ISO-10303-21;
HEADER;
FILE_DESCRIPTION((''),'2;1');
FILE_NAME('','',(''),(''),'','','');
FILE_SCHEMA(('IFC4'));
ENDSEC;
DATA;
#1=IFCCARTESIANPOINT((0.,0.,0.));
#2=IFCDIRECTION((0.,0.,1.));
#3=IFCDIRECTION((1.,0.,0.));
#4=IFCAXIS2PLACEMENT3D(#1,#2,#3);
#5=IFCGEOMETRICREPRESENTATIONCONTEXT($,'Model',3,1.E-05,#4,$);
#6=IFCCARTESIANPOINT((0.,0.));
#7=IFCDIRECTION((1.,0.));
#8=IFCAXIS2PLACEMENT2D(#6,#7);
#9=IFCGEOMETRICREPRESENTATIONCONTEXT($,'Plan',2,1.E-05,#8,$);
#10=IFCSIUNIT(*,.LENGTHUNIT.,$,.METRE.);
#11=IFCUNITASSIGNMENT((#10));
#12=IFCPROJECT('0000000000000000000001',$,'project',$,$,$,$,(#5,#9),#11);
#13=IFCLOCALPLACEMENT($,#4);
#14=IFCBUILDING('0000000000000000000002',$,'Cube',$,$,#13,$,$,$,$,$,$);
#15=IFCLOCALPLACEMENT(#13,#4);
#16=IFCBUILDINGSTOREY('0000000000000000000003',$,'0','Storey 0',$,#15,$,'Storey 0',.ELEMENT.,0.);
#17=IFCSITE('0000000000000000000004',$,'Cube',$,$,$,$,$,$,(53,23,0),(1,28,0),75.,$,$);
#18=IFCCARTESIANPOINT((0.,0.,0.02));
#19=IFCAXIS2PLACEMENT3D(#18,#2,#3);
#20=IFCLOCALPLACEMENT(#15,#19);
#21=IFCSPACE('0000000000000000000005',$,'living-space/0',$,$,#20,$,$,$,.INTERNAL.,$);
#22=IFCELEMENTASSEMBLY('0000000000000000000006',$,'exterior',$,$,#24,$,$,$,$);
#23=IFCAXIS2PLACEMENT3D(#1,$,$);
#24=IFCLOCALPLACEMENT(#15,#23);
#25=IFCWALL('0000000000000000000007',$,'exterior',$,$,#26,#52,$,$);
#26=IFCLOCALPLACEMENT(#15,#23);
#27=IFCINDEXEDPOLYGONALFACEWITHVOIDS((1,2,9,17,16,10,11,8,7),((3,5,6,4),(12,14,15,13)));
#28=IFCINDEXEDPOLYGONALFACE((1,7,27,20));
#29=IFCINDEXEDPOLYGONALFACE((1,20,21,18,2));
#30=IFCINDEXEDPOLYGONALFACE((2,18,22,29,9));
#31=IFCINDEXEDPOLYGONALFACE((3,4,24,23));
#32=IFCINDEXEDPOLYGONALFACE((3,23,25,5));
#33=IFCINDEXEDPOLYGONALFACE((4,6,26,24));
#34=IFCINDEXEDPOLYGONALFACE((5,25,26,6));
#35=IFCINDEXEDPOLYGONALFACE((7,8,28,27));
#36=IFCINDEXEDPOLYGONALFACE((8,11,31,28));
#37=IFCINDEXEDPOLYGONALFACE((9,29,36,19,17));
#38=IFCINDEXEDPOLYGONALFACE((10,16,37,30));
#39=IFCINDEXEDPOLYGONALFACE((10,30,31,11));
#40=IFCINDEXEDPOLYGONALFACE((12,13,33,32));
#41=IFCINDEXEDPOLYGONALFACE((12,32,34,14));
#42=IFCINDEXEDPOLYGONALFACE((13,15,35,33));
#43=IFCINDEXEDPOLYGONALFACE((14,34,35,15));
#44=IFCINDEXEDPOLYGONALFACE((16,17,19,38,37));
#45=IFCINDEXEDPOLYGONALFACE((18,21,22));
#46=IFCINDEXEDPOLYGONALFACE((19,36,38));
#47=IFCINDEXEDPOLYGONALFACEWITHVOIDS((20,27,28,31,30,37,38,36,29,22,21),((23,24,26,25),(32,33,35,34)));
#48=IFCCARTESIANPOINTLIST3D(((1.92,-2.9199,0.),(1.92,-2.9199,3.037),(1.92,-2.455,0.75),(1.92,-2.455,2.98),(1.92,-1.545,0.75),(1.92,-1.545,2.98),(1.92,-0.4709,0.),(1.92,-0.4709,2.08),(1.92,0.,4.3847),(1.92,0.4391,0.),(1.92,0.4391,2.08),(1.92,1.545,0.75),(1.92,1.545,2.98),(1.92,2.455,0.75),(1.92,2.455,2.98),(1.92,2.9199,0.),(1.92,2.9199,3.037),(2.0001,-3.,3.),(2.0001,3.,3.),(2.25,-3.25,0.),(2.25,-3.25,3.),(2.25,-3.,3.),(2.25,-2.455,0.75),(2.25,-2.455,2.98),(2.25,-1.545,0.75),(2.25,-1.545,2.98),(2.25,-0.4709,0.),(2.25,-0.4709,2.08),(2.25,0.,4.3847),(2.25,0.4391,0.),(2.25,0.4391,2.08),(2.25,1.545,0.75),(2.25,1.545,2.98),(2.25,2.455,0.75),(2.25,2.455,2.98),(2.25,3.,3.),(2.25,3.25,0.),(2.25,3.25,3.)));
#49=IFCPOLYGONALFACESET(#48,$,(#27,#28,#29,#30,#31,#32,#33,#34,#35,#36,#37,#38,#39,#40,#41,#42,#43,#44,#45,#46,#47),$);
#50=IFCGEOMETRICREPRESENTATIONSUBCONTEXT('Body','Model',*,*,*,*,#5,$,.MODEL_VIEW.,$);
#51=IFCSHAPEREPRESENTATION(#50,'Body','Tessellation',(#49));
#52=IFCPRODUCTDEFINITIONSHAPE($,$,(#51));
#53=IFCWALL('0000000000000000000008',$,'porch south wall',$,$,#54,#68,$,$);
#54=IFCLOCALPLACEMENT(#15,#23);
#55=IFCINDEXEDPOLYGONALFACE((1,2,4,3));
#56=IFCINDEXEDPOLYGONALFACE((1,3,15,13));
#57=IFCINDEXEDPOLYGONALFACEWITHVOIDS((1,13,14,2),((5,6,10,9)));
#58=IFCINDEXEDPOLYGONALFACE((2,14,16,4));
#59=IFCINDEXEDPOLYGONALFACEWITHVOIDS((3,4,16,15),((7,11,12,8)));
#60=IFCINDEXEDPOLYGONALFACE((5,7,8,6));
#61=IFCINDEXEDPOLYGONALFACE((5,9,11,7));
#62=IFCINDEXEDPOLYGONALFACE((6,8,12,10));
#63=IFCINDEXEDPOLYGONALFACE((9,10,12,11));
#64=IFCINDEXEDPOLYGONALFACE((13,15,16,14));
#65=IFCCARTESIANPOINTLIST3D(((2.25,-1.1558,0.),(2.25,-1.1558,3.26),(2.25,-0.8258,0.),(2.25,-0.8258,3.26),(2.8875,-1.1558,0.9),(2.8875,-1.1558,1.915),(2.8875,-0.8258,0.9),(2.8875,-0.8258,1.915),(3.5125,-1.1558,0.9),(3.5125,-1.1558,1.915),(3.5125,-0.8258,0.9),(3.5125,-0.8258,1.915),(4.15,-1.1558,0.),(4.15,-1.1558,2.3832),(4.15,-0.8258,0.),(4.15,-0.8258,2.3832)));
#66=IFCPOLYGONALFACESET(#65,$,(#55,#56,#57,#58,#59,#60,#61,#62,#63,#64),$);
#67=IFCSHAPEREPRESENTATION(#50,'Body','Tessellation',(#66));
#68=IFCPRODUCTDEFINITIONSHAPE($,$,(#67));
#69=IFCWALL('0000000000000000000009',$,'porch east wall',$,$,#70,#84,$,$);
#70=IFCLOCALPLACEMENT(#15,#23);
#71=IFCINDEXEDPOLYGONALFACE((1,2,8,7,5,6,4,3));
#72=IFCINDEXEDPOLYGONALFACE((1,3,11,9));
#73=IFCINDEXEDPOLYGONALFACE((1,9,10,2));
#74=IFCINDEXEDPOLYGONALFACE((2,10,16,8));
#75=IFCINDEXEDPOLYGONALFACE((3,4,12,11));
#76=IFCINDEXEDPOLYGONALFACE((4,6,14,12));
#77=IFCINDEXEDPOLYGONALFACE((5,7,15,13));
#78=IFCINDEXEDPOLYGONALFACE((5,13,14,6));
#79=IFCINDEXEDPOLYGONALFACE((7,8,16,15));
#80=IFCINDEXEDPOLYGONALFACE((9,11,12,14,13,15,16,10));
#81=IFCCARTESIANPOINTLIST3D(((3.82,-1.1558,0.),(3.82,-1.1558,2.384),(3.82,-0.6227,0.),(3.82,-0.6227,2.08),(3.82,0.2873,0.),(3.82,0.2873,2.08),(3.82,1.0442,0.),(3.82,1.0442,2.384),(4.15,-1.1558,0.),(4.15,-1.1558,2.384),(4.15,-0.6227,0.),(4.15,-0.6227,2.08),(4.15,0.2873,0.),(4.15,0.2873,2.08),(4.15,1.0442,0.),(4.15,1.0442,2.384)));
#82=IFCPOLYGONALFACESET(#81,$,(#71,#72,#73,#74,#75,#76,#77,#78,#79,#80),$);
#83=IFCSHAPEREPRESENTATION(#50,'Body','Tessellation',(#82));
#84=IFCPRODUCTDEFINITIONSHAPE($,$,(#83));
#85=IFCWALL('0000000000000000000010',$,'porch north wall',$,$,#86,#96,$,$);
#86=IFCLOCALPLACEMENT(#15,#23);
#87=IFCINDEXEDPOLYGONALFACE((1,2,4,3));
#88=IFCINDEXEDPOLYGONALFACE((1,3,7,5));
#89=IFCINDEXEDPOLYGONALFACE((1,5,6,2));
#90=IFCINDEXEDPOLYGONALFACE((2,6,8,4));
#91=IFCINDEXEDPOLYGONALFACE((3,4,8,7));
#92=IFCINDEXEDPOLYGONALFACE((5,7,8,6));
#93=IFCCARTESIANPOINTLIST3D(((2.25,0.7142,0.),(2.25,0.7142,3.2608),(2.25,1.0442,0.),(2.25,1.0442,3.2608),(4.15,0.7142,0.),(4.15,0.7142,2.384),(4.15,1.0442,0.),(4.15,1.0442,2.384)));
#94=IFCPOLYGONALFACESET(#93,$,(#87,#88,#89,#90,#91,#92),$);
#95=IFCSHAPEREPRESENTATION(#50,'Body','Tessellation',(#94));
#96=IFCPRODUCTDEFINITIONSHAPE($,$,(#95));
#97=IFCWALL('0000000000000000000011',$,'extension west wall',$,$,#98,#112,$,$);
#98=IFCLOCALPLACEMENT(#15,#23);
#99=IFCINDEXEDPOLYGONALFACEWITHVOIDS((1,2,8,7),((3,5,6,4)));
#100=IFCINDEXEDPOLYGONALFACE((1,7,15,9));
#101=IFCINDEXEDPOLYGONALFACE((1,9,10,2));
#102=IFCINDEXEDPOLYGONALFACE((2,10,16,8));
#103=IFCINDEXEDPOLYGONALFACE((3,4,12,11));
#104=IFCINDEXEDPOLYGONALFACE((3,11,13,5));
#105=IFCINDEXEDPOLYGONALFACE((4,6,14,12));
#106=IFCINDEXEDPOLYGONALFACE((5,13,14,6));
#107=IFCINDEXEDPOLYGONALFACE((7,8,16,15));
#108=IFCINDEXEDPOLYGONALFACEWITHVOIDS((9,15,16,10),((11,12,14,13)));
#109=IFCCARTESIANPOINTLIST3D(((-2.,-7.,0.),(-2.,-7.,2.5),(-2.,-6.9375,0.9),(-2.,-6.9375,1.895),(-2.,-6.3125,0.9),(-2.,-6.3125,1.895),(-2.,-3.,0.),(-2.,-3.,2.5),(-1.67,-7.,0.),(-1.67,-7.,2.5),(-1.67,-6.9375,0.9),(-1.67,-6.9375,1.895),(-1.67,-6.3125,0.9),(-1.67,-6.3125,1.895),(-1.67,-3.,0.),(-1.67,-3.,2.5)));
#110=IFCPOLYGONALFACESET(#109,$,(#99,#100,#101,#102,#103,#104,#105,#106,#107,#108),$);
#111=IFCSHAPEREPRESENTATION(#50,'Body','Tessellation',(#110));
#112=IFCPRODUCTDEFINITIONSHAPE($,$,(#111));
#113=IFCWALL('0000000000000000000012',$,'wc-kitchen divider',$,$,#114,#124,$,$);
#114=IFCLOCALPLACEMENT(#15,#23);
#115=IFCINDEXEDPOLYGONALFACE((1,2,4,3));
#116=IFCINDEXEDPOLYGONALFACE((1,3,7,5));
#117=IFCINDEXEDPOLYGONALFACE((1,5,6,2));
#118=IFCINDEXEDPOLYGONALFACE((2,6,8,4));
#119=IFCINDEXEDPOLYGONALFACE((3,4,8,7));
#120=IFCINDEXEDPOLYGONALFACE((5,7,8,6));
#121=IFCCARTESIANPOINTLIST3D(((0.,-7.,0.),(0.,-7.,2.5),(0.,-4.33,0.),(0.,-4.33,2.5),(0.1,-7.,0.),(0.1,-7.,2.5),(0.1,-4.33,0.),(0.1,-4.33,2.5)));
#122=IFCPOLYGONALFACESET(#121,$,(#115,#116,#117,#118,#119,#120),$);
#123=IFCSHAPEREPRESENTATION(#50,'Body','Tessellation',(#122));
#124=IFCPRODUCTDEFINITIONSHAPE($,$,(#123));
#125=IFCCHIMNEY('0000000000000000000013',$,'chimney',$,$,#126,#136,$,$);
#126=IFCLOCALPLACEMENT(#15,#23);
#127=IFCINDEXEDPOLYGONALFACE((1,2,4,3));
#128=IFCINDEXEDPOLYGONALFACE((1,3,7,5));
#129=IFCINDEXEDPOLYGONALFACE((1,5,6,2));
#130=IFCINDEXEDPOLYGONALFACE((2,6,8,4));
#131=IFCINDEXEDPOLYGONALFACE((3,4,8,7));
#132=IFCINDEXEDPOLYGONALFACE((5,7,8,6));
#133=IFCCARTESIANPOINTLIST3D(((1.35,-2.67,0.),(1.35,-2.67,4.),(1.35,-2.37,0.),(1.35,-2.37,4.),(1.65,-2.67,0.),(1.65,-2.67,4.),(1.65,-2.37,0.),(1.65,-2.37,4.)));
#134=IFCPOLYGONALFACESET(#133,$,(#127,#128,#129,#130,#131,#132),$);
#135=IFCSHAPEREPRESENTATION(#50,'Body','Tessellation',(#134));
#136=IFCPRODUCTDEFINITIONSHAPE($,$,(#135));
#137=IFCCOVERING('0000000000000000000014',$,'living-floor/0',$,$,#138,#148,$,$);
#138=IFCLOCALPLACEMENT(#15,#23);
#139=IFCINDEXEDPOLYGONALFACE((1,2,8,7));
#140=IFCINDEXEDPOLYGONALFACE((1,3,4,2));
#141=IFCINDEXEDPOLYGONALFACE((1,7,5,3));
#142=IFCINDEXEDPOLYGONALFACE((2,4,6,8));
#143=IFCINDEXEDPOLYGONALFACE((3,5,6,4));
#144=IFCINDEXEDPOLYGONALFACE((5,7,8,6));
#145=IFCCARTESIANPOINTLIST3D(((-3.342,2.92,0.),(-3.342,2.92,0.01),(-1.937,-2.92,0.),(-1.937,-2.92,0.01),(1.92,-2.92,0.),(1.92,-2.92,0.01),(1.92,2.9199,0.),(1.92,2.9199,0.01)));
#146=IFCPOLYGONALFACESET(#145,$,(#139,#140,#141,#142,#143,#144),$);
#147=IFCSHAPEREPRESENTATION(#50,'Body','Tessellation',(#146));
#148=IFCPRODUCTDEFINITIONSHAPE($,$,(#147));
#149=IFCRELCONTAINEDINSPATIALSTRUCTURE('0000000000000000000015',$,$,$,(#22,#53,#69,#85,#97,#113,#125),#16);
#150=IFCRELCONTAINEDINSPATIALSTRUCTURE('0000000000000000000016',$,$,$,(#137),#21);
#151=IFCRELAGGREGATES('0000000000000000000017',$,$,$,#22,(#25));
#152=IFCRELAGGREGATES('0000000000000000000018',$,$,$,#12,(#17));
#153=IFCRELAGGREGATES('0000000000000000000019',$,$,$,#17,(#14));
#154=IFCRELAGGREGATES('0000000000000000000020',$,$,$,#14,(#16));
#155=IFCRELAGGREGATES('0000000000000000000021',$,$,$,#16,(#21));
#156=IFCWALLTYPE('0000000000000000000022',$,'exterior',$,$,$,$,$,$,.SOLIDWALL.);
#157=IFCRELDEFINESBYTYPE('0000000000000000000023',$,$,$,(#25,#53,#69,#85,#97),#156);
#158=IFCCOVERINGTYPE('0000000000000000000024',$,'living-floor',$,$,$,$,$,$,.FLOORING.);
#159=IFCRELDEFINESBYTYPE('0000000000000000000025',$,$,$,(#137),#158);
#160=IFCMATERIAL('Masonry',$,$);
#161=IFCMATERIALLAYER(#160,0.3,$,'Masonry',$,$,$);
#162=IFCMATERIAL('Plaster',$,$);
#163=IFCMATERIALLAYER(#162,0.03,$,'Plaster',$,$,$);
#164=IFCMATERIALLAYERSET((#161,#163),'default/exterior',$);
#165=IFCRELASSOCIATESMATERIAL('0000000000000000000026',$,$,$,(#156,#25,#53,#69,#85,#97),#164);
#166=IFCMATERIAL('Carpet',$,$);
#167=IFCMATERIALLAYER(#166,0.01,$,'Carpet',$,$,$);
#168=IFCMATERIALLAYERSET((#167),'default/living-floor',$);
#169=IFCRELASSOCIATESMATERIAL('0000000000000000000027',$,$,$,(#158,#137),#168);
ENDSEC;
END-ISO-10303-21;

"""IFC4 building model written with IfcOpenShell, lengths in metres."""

from ifc_helpers import new_model, si_unit, frame, origin, origin_with_axes, origin_2d_with_axis, place, context, subcontext, project, spatial, polyline, line, indexed_curve, outline, extrude, clip, halfspace, bounded_halfspace, source, transform, mapped, material, layer, layer_set, layer_usage, type_object, element, aggregate, save


model = new_model("IFC4")

# Units and contexts
model_context = context("Model", 3, precision=1e-05, world=origin_with_axes())
plan_context = context("Plan", 2, precision=1e-05, world=origin_2d_with_axis())
body_context = subcontext(model_context, "Body", "Model", "MODEL_VIEW")
ifc_project = project(units=[si_unit("LENGTHUNIT", "METRE")], contexts=[model_context, plan_context])

# Site, building, storey
site = spatial("IfcSite", under=ifc_project, Name="Cube", RefLatitude=(53, 23, 0), RefLongitude=(1, 28, 0), RefElevation=75.0)
building_placement = place(None, origin_with_axes())
building = spatial("IfcBuilding", under=site, at=building_placement, Name="Cube")
storey_placement = place(building_placement, origin_with_axes())
storey = spatial("IfcBuildingStorey", under=building, at=storey_placement, Name="0", Description="Storey 0", LongName="Storey 0", CompositionType="ELEMENT", Elevation=0.0)

# Element assembly, wall, openings
ifc_material_1 = material(Name="Masonry")
ifc_layer_1 = layer(ifc_material_1, 0.3, Name="Masonry")
ifc_material_2 = material(Name="Plaster")
ifc_layer_2 = layer(ifc_material_2, 0.03, Name="Plaster")
ifc_layer_set_1 = layer_set([ifc_layer_1, ifc_layer_2], Name="default/exterior")
wall_type = type_object("IfcWallType", Name="exterior", PredefinedType="SOLIDWALL", material=ifc_layer_set_1)
assembly_1_placement = place(storey_placement, frame((2.0, -3.0, 0.0), z_axis=(0.0, 0.0, 1.0), x_axis=(0.0, 1.0, 0.0)))
assembly_1 = element("IfcElementAssembly", 1, at=assembly_1_placement, inside=storey, Name="exterior")
ifc_layer_usage_1 = layer_usage(ifc_layer_set_1, "AXIS2", "POSITIVE", -0.25)
wall_1_placement = place(assembly_1_placement, origin_with_axes())
wall_1 = element("IfcWall", 2, at=wall_1_placement, type_object=wall_type, material=ifc_layer_usage_1, Name="exterior", context=body_context, shape_type="Clipping", body=[
    clip(clip(clip(clip(extrude(outline(polyline([(0.0801, 0.08), (-0.25, -0.25), (6.25, -0.25), (5.9199, 0.08), (0.0801, 0.08)])), origin(), (0.0, 0.0, 1.0), 4.385), bounded_halfspace(frame((6.0, 0.0, 3.0), z_axis=(0.419069, 0.0, 0.907954), x_axis=(0.0, -1.0, 0.0)), False, origin(), polyline([(6.0, -1.0), (3.0, -1.0), (3.0, 1.0), (6.0, 1.0), (6.0, -1.0)]))), bounded_halfspace(frame((6.0, 0.0, 3.0), z_axis=(0.0, 0.0, 1.0), x_axis=(0.0, 1.0, 0.0)), False, origin(), polyline([(6.0, 1.0), (7.0, 1.0), (7.0, -1.0), (6.0, -1.0), (6.0, 1.0)]))), bounded_halfspace(frame((3.0, 0.0, 4.3847), z_axis=(-0.419069, 0.0, 0.907954), x_axis=(0.0, -1.0, 0.0)), False, origin(), polyline([(3.0, -1.0), (0.0, -1.0), (0.0, 1.0), (3.0, 1.0), (3.0, -1.0)]))), bounded_halfspace(frame((0.0, 0.0, 3.0), z_axis=(0.0, 0.0, 1.0), x_axis=(0.0, -1.0, 0.0)), False, origin(), polyline([(0.0, -1.0), (-1.0, -1.0), (-1.0, 1.0), (0.0, 1.0), (0.0, -1.0)]))),
])
opening_1_placement = place(wall_1_placement, frame((0.545, -0.25, 0.75), z_axis=(0.0, 0.0, 1.0), x_axis=(1.0, 0.0, 0.0)))
element("IfcOpeningElement", 3, at=opening_1_placement, cuts=wall_1, PredefinedType="OPENING", context=body_context, shape_type="SweptSolid", body=[
    extrude(outline(polyline([(0.0, -0.02), (0.91, -0.02), (0.91, 0.35), (0.0, 0.35), (0.0, -0.02)])), origin(), (0.0, 0.0, 1.0), 2.23),
])
opening_2_placement = place(wall_1_placement, frame((4.545, -0.25, 0.75), z_axis=(0.0, 0.0, 1.0), x_axis=(1.0, 0.0, 0.0)))
element("IfcOpeningElement", 4, at=opening_2_placement, cuts=wall_1, PredefinedType="OPENING", context=body_context, shape_type="SweptSolid", body=[
    extrude(outline(polyline([(0.0, -0.02), (0.91, -0.02), (0.91, 0.35), (0.0, 0.35), (0.0, -0.02)])), origin(), (0.0, 0.0, 1.0), 2.23),
])
shared_shape_1 = source(origin_with_axes(), body_context, "Body", "SweptSolid", [
    extrude(outline(indexed_curve([(0.0, 0.0), (0.91, 0.0), (0.91, 2.08), (0.0, 2.08)], segments=[line(1, 2, 3, 4, 1)])), frame((0.0, -0.6, 0.0), z_axis=(0.0, -1.0, 0.0), x_axis=(1.0, 0.0, 0.0)), (0.0, 0.0, -1.0), 1.2),
])
opening_3_placement = place(wall_1_placement, frame((2.5291, -0.25, 0.0), z_axis=(0.0, 0.0, 1.0), x_axis=(1.0, 0.0, 0.0)))
element("IfcOpeningElement", 5, at=opening_3_placement, cuts=wall_1, PredefinedType="OPENING", context=body_context, shape_type="MappedRepresentation", body=[
    mapped(shared_shape_1, transform((0.0, 0.0, 0.0), x_axis=(1.0, 0.0, 0.0), y_axis=(0.0, 1.0, 0.0), z_axis=(0.0, 0.0, 1.0), scale=1.0)),
])
aggregate(assembly_1, [wall_1])

# Walls, openings
ifc_layer_usage_2 = layer_usage(ifc_layer_set_1, "AXIS2", "POSITIVE", 0.0)
wall_2_placement = place(storey_placement, frame((2.25, -1.1558, 0.0), z_axis=(0.0, 0.0, 1.0), x_axis=(1.0, 0.0, 0.0)))
wall_2 = element("IfcWall", 6, at=wall_2_placement, inside=storey, type_object=wall_type, material=ifc_layer_usage_2, Name="porch south wall", context=body_context, shape_type="Clipping", body=[
    clip(extrude(outline(indexed_curve([(0.0, 0.0), (0.0, 0.33), (1.9, 0.33), (1.9, 0.0), (0.0, 0.0)], self_intersect=False)), origin_with_axes(), (0.0, 0.0, 1.0), 3.5), halfspace(frame((0.0, 0.0, 3.26), z_axis=(0.419, 0.0, 0.908), x_axis=(0.0, 1.0, 0.0)), False)),
])
opening_4_placement = place(wall_2_placement, frame((0.6375, -0.0002, 0.9), z_axis=(0.0, 0.0, 1.0), x_axis=(1.0, 0.0, 0.0)))
element("IfcOpeningElement", 7, at=opening_4_placement, cuts=wall_2, context=body_context, shape_type="SweptSolid", body=[
    extrude(outline(indexed_curve([(0.0, 0.0), (0.0, 0.5), (0.625, 0.5), (0.625, 0.0), (0.0, 0.0)], self_intersect=False)), origin_with_axes(), (0.0, 0.0, 1.0), 1.015),
])
ifc_layer_usage_3 = layer_usage(ifc_layer_set_1, "AXIS2", "POSITIVE", 0.0)
wall_3_placement = place(storey_placement, frame((4.15, -1.1558, 0.0), z_axis=(0.0, 0.0, 1.0), x_axis=(0.0, 1.0, 0.0)))
wall_3 = element("IfcWall", 8, at=wall_3_placement, inside=storey, type_object=wall_type, material=ifc_layer_usage_3, Name="porch east wall", context=body_context, shape_type="SweptSolid", body=[
    extrude(outline(indexed_curve([(0.0, 0.0), (0.0, 0.33), (2.2, 0.33), (2.2, 0.0), (0.0, 0.0)], self_intersect=False)), origin_with_axes(), (0.0, 0.0, 1.0), 2.384),
])
shared_shape_2 = source(origin_with_axes(), body_context, "Body", "SweptSolid", [
    extrude(outline(indexed_curve([(0.0, 0.0), (0.91, 0.0), (0.91, 2.08), (0.0, 2.08)], segments=[line(1, 2, 3, 4, 1)])), frame((0.0, -0.6, 0.0), z_axis=(0.0, -1.0, 0.0), x_axis=(1.0, 0.0, 0.0)), (0.0, 0.0, -1.0), 1.2),
])
opening_5_placement = place(wall_3_placement, frame((0.5331, 0.0, 0.0), z_axis=(0.0, 0.0, 1.0), x_axis=(1.0, 0.0, 0.0)))
element("IfcOpeningElement", 9, at=opening_5_placement, cuts=wall_3, PredefinedType="OPENING", context=body_context, shape_type="MappedRepresentation", body=[
    mapped(shared_shape_2, transform((0.0, 0.0, 0.0), x_axis=(1.0, 0.0, 0.0), y_axis=(0.0, 1.0, 0.0), z_axis=(0.0, 0.0, 1.0), scale=1.0)),
])

# Wall
ifc_layer_usage_4 = layer_usage(ifc_layer_set_1, "AXIS2", "POSITIVE", 0.0)
wall_4_placement = place(storey_placement, frame((4.15, 1.0442, 0.0), z_axis=(0.0, 0.0, 1.0), x_axis=(-1.0, 0.0, 0.0)))
element("IfcWall", 10, at=wall_4_placement, inside=storey, type_object=wall_type, material=ifc_layer_usage_4, Name="porch north wall", context=body_context, shape_type="Clipping", body=[
    clip(extrude(outline(indexed_curve([(0.0, 0.0), (0.0, 0.33), (1.9, 0.33), (1.9, 0.0), (0.0, 0.0)], self_intersect=False)), origin_with_axes(), (0.0, 0.0, 1.0), 3.5), halfspace(frame((0.0, 0.0, 2.384), z_axis=(-0.419, 0.0, 0.908), x_axis=(0.0, -1.0, 0.0)), False)),
])

# Wall, opening
ifc_layer_usage_5 = layer_usage(ifc_layer_set_1, "AXIS2", "POSITIVE", 0.0)
wall_5_placement = place(storey_placement, frame((-2.0, -3.0, 0.0), z_axis=(0.0, 0.0, 1.0), x_axis=(0.0, -1.0, 0.0)))
wall_5 = element("IfcWall", 11, at=wall_5_placement, inside=storey, type_object=wall_type, material=ifc_layer_usage_5, Name="extension west wall", context=body_context, shape_type="SweptSolid", body=[
    extrude(outline(indexed_curve([(0.0, 0.0), (0.0, 0.33), (4.0, 0.33), (4.0, 0.0), (0.0, 0.0)], self_intersect=False)), origin_with_axes(), (0.0, 0.0, 1.0), 2.5),
])
opening_6_placement = place(wall_5_placement, frame((3.3125, 0.0, 0.9), z_axis=(0.0, 0.0, 1.0), x_axis=(1.0, 0.0, 0.0)))
element("IfcOpeningElement", 12, at=opening_6_placement, cuts=wall_5, PredefinedType="OPENING", context=body_context, shape_type="SweptSolid", body=[
    extrude(outline(indexed_curve([(0.0, 0.0), (0.0, 0.5), (0.625, 0.5), (0.625, 0.0), (0.0, 0.0)], self_intersect=False)), origin_with_axes(), (0.0, 0.0, 1.0), 0.995),
])

# Wall
wall_6_placement = place(storey_placement, frame((0.0, -4.33, 0.0), z_axis=(0.0, 0.0, 1.0), x_axis=(0.0, -1.0, 0.0)))
element("IfcWall", 13, at=wall_6_placement, inside=storey, Name="wc-kitchen divider", context=body_context, shape_type="SweptSolid", body=[
    extrude(outline(indexed_curve([(0.0, 0.0), (0.0, 0.1), (2.67, 0.1), (2.67, 0.0), (0.0, 0.0)], self_intersect=False)), origin_with_axes(), (0.0, 0.0, 1.0), 2.5),
])

# Chimney
chimney_placement = place(storey_placement, frame((1.35, -2.67, 0.0), z_axis=(0.0, 0.0, 1.0), x_axis=(1.0, 0.0, 0.0)))
element("IfcChimney", 14, at=chimney_placement, inside=storey, Name="chimney", context=body_context, shape_type="SweptSolid", body=[
    extrude(outline(indexed_curve([(0.0, 0.0), (0.3, 0.0), (0.3, 0.3), (0.0, 0.3)])), None, (0.0, 0.0, 1.0), 4.0),
])

# Shared definitions
space_placement = place(storey_placement, frame((0.0, 0.0, 0.02), z_axis=(0.0, 0.0, 1.0), x_axis=(1.0, 0.0, 0.0)))
space = spatial("IfcSpace", under=storey, at=space_placement, Name="living-space/0", PredefinedType="INTERNAL")

# Covering
ifc_material_3 = material(Name="Carpet")
ifc_layer_3 = layer(ifc_material_3, 0.01, Name="Carpet")
ifc_layer_set_2 = layer_set([ifc_layer_3], Name="default/living-floor")
ifc_layer_usage_6 = layer_usage(ifc_layer_set_2, "AXIS3", "POSITIVE", 0.0)
covering_type = type_object("IfcCoveringType", Name="living-floor", PredefinedType="FLOORING", material=ifc_layer_set_2)
covering_placement = place(space_placement, frame((0.0, 0.0, -0.02), z_axis=(0.0, 0.0, 1.0), x_axis=(1.0, 0.0, 0.0)))
element("IfcCovering", 15, at=covering_placement, inside=space, type_object=covering_type, material=ifc_layer_usage_6, Name="living-floor/0", context=body_context, shape_type="SweptSolid", body=[
    extrude(outline(polyline([(1.92, 2.9199), (-3.342, 2.92), (-1.937, -2.92), (1.92, -2.92), (1.92, 2.9199)])), origin_with_axes(), (0.0, 0.0, 1.0), 0.01),
])

save(model, "model.ifc")
